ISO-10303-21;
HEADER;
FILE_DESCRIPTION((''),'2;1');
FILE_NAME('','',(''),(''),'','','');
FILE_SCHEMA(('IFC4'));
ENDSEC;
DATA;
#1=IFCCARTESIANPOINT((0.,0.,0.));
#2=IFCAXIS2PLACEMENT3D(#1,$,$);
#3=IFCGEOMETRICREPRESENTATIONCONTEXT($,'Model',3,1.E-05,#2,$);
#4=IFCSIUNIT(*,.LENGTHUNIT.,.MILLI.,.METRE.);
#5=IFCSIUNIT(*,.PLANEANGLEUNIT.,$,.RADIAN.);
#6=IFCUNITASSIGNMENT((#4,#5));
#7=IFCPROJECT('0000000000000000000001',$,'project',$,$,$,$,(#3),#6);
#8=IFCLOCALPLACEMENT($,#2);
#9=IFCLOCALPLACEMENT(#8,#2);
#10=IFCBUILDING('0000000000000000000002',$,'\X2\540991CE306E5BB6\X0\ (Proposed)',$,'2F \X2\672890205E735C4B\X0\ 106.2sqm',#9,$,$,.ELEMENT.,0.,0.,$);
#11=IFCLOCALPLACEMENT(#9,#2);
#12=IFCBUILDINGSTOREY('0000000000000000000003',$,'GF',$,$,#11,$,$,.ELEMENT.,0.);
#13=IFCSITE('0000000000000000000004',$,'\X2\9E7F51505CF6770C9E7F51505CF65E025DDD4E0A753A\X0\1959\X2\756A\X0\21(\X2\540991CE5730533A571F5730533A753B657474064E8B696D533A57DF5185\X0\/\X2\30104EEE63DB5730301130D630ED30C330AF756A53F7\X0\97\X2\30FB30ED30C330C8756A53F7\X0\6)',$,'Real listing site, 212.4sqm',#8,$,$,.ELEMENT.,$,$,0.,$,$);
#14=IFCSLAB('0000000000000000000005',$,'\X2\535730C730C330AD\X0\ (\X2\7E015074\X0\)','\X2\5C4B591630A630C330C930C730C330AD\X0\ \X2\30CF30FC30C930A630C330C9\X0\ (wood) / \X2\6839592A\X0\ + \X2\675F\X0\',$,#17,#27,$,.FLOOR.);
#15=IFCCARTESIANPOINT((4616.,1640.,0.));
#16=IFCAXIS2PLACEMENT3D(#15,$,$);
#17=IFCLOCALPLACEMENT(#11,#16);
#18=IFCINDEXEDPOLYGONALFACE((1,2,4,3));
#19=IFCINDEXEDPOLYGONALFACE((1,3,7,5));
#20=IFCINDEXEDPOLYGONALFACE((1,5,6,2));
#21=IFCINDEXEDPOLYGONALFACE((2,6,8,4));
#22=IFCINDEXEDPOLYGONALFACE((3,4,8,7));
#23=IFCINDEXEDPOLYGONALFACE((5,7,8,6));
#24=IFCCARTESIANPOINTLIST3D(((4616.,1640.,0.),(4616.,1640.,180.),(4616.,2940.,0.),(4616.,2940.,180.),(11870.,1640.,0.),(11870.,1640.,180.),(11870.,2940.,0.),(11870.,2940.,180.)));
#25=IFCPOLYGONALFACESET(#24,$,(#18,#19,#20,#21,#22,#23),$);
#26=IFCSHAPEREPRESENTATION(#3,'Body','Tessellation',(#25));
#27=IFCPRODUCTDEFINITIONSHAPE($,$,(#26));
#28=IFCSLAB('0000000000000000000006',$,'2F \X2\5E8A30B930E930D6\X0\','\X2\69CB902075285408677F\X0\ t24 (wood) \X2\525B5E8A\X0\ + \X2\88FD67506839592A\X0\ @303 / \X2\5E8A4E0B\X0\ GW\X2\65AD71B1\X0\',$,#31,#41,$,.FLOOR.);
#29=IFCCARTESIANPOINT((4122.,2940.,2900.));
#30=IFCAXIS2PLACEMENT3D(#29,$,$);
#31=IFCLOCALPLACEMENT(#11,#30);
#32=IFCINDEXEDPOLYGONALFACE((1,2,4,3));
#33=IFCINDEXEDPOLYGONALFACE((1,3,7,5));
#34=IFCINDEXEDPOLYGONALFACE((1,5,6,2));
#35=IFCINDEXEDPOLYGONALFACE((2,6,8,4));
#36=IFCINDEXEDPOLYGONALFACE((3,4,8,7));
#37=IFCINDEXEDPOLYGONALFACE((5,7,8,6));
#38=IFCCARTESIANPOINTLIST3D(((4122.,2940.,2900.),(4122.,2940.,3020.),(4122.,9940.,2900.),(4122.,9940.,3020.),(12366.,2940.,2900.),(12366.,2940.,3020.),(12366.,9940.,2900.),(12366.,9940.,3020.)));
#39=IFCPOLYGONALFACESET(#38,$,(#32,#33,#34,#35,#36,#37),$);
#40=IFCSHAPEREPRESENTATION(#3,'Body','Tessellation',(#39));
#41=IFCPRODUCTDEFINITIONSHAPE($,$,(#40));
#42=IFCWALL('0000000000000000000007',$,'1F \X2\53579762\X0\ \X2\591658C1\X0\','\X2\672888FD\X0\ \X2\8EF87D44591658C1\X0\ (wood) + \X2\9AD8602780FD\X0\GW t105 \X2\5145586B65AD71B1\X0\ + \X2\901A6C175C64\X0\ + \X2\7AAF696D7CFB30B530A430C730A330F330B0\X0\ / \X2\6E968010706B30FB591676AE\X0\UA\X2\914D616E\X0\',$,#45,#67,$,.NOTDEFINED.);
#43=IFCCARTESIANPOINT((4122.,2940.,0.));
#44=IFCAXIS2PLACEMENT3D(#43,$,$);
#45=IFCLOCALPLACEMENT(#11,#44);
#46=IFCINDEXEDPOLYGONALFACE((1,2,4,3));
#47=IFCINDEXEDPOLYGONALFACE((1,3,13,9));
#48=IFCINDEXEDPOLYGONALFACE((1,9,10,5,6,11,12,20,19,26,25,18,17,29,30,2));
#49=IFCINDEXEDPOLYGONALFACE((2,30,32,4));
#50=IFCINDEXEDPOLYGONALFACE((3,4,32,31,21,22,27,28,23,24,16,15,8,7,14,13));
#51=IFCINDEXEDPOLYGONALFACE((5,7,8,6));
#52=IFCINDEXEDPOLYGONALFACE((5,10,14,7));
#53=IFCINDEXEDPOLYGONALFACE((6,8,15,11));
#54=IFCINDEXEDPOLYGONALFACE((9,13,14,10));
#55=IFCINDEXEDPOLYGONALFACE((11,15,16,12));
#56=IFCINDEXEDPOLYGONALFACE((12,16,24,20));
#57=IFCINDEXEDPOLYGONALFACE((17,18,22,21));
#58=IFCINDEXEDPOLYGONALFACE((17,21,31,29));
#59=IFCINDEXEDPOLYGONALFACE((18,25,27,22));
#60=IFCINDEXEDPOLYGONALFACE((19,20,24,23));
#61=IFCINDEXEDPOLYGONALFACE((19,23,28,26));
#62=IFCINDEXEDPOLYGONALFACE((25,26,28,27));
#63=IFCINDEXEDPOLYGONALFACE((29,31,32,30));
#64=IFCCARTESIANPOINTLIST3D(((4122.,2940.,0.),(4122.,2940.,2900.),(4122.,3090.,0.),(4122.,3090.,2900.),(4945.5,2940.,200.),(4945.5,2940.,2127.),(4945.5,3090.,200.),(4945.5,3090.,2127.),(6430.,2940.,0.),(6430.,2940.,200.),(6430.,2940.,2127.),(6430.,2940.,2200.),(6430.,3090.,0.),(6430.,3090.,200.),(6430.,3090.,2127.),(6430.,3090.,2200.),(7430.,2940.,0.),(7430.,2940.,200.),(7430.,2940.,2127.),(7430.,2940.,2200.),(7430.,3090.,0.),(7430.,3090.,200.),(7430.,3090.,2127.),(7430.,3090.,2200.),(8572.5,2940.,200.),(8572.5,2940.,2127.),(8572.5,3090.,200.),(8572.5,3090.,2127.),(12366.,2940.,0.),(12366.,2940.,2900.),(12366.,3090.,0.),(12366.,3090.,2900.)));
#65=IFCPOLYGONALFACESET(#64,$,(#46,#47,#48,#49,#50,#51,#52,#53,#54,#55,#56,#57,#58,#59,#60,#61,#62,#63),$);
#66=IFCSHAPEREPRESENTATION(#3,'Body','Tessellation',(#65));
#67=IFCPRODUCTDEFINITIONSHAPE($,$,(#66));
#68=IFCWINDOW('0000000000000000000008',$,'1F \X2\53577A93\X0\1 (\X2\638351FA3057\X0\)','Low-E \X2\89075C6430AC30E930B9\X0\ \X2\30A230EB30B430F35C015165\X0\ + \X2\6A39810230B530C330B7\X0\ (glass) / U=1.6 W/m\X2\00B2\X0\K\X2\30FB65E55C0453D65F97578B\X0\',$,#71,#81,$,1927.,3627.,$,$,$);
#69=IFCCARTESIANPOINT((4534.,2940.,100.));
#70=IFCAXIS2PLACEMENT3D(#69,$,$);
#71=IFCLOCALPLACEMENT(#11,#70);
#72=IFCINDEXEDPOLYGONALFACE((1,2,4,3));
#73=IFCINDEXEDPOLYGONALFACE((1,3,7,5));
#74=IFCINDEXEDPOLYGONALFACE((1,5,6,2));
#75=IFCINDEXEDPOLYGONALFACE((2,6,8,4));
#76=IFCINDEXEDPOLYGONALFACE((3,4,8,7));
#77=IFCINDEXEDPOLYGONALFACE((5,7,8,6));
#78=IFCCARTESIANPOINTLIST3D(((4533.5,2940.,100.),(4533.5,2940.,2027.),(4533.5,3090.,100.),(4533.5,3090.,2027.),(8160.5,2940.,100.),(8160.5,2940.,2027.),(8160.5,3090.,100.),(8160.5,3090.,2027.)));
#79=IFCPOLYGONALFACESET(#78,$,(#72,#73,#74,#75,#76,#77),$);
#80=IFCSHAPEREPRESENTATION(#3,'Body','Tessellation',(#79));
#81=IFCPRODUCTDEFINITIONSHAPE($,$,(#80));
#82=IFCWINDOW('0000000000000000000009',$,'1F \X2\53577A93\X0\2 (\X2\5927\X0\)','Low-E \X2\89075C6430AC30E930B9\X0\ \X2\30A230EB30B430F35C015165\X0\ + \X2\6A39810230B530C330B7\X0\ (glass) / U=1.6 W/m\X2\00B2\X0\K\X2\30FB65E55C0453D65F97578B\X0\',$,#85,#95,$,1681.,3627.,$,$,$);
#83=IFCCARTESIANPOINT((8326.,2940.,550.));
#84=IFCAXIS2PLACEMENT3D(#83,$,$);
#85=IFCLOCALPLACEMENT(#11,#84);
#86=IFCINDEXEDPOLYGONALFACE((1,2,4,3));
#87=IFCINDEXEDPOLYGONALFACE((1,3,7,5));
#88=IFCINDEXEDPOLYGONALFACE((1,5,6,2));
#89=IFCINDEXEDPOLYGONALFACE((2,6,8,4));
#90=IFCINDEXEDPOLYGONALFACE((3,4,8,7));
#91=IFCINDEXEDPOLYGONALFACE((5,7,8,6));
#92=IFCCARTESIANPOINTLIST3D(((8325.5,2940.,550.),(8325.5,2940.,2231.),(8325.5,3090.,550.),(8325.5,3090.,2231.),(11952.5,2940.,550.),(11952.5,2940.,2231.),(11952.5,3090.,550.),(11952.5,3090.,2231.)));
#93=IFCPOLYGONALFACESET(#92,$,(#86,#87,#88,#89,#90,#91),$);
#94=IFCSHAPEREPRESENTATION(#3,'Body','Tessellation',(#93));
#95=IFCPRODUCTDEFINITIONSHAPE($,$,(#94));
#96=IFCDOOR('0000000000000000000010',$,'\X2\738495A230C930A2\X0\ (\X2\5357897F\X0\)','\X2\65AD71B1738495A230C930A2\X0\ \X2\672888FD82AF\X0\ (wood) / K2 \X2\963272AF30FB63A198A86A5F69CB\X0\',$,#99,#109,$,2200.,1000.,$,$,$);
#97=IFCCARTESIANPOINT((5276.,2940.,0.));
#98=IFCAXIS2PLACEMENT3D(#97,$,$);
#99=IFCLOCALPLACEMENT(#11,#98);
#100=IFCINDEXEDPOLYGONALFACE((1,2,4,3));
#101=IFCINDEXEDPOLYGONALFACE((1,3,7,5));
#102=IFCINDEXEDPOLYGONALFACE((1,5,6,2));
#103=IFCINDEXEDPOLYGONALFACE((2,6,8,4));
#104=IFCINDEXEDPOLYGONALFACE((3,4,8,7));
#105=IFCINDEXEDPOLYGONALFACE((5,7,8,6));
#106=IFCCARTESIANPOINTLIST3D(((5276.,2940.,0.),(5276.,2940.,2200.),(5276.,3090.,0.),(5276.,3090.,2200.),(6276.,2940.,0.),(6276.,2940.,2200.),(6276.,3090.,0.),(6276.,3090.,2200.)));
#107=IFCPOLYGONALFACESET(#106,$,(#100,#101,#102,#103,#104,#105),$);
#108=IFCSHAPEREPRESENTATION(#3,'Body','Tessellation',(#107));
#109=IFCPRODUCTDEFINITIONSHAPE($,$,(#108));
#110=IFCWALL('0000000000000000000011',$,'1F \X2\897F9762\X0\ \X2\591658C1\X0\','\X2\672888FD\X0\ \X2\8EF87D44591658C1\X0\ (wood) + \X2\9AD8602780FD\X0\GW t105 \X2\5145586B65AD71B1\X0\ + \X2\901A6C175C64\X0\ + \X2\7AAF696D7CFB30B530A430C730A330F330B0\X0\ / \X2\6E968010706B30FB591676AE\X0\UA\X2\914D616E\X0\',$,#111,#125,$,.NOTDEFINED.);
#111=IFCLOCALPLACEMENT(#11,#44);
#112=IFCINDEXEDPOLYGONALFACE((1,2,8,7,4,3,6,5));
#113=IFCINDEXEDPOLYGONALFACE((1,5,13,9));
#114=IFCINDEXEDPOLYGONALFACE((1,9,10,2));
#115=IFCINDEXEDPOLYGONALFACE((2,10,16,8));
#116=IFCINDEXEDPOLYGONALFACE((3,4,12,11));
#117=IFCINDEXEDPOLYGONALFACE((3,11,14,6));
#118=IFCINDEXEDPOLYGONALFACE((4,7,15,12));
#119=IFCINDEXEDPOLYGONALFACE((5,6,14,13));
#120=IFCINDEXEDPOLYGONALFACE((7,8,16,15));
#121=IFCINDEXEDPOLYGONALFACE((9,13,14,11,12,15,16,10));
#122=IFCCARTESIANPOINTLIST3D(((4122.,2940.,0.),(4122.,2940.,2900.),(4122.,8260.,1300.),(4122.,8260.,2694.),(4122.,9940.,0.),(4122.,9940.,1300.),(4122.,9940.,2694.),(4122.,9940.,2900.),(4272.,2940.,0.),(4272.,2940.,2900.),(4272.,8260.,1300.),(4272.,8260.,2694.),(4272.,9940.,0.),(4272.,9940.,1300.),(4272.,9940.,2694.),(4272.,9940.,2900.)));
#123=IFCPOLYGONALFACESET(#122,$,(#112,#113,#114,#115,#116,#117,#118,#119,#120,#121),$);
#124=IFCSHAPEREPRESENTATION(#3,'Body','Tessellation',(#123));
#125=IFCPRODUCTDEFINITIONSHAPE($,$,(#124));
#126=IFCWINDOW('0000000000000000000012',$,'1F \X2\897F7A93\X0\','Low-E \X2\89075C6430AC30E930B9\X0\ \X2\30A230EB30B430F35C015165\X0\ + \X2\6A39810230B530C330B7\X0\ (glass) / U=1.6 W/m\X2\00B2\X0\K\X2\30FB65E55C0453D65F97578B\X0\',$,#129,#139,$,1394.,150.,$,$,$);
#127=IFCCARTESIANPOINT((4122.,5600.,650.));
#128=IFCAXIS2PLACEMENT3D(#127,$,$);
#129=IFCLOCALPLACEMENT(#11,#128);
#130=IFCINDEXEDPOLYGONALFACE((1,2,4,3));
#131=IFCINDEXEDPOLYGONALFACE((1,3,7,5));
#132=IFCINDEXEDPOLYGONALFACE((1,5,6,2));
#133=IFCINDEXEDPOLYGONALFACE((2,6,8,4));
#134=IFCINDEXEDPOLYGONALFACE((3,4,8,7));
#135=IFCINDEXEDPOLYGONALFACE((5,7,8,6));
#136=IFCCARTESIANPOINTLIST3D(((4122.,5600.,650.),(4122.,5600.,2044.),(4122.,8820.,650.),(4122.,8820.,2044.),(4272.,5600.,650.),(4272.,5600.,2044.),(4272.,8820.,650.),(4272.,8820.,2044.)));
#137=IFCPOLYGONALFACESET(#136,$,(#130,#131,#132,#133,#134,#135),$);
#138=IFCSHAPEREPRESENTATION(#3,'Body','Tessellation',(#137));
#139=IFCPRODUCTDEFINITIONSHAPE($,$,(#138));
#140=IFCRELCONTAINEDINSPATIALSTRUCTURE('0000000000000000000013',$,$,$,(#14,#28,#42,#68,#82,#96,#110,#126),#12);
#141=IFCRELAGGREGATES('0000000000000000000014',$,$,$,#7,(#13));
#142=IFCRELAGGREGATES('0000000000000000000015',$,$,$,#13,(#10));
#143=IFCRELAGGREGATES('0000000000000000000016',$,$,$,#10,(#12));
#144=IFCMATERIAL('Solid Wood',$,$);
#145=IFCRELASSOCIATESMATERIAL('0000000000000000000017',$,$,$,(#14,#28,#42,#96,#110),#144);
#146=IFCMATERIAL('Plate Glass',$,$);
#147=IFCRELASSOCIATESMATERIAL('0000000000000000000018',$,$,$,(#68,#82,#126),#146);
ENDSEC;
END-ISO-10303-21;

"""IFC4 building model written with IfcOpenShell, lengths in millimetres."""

from ifc_helpers import new_model, si_unit, frame, frame_2d, origin, place, context, project, spatial, rectangle, extrude, material, element, fill, save


model = new_model("IFC4")

# Units and contexts
model_context = context("Model", 3, precision=1e-05, world=origin())
ifc_project = project(units=[si_unit("LENGTHUNIT", "METRE", prefix="MILLI"), si_unit("PLANEANGLEUNIT", "RADIAN")], contexts=[model_context])

# Site, building, storey
site_placement = place(None, origin())
site = spatial("IfcSite", under=ifc_project, at=site_placement, Name="鹿児島県鹿児島市川上町1959番21(吉野地区土地区画整理事業区域内/【仮換地】ブロック番号97・ロット番号6)", ObjectType="Real listing site, 212.4sqm", CompositionType="ELEMENT", RefElevation=0.0)
building_placement = place(site_placement, origin())
building = spatial("IfcBuilding", under=site, at=building_placement, Name="吉野の家 (Proposed)", ObjectType="2F 木造平屋 106.2sqm", CompositionType="ELEMENT", ElevationOfRefHeight=0.0, ElevationOfTerrain=0.0)
storey_placement = place(building_placement, origin())
storey = spatial("IfcBuildingStorey", under=building, at=storey_placement, Name="GF", CompositionType="ELEMENT", Elevation=0.0)

# Slabs
ifc_material_1 = material(Name="Solid Wood")
slab_1_placement = place(storey_placement, frame((4616.0, 1640.0, 0.0)))
element("IfcSlab", 1, at=slab_1_placement, inside=storey, material=ifc_material_1, Name="南デッキ (縁側)", Description="屋外ウッドデッキ ハードウッド (wood) / 根太 + 束", PredefinedType="FLOOR", context=model_context, shape_type="SweptSolid", body=[
    extrude(rectangle(XDim=7254.0, YDim=1300.0, at=frame_2d((3627.0, 650.0))), frame((4616.0, 1640.0, 0.0)), (0.0, 0.0, 1.0), 180.0),
])
slab_2_placement = place(storey_placement, frame((4122.0, 2940.0, 2900.0)))
element("IfcSlab", 2, at=slab_2_placement, inside=storey, material=ifc_material_1, Name="2F 床スラブ", Description="構造用合板 t24 (wood) 剛床 + 製材根太 @303 / 床下 GW断熱", PredefinedType="FLOOR", context=model_context, shape_type="SweptSolid", body=[
    extrude(rectangle(XDim=8244.0, YDim=7000.0, at=frame_2d((4122.0, 3500.0))), frame((4122.0, 2940.0, 2900.0)), (0.0, 0.0, 1.0), 120.0),
])

# Wall, openings, windows, door
wall_1_placement = place(storey_placement, frame((4122.0, 2940.0, 0.0)))
wall_1 = element("IfcWall", 3, at=wall_1_placement, inside=storey, material=ifc_material_1, Name="1F 南面 外壁", Description="木製 軸組外壁 (wood) + 高性能GW t105 充填断熱 + 通気層 + 窯業系サイディング / 準耐火・外皮UA配慮", PredefinedType="NOTDEFINED", context=model_context, shape_type="SweptSolid", body=[
    extrude(rectangle(XDim=8244.0, YDim=150.0, at=frame_2d((4122.0, 75.0))), frame((4122.0, 2940.0, 0.0)), (0.0, 0.0, 1.0), 2900.0),
])
opening_1_placement = place(storey_placement, frame((4534.0, 2940.0, 100.0)))
opening_1 = element("IfcOpeningElement", 4, at=opening_1_placement, cuts=wall_1, PredefinedType="NOTDEFINED", context=model_context, shape_type="SweptSolid", body=[
    extrude(rectangle(XDim=3627.0, YDim=150.0, at=frame_2d((1813.0, 75.0))), frame((4534.0, 2940.0, 100.0)), (0.0, 0.0, 1.0), 1927.0),
])
opening_2_placement = place(storey_placement, frame((8326.0, 2940.0, 550.0)))
opening_2 = element("IfcOpeningElement", 5, at=opening_2_placement, cuts=wall_1, PredefinedType="NOTDEFINED", context=model_context, shape_type="SweptSolid", body=[
    extrude(rectangle(XDim=3627.0, YDim=150.0, at=frame_2d((1813.0, 75.0))), frame((8326.0, 2940.0, 550.0)), (0.0, 0.0, 1.0), 1681.0),
])
opening_3_placement = place(storey_placement, frame((5276.0, 2940.0, 0.0)))
opening_3 = element("IfcOpeningElement", 6, at=opening_3_placement, cuts=wall_1, PredefinedType="NOTDEFINED", context=model_context, shape_type="SweptSolid", body=[
    extrude(rectangle(XDim=1000.0, YDim=150.0, at=frame_2d((500.0, 75.0))), frame((5276.0, 2940.0, 0.0)), (0.0, 0.0, 1.0), 2200.0),
])
ifc_material_2 = material(Name="Plate Glass")
window_1_placement = place(storey_placement, frame((4534.0, 2940.0, 100.0)))
window_1 = element("IfcWindow", 7, at=window_1_placement, inside=storey, material=ifc_material_2, Name="1F 南窓1 (掃出し)", Description="Low-E 複層ガラス アルゴン封入 + 樹脂サッシ (glass) / U=1.6 W/m²K・日射取得型", OverallHeight=1927.0, OverallWidth=3627.0, context=model_context, shape_type="SweptSolid", body=[
    extrude(rectangle(XDim=3627.0, YDim=150.0, at=frame_2d((1813.0, 75.0))), frame((4534.0, 2940.0, 100.0)), (0.0, 0.0, 1.0), 1927.0),
])
fill(opening_1, window_1)
window_2_placement = place(storey_placement, frame((8326.0, 2940.0, 550.0)))
window_2 = element("IfcWindow", 8, at=window_2_placement, inside=storey, material=ifc_material_2, Name="1F 南窓2 (大)", Description="Low-E 複層ガラス アルゴン封入 + 樹脂サッシ (glass) / U=1.6 W/m²K・日射取得型", OverallHeight=1681.0, OverallWidth=3627.0, context=model_context, shape_type="SweptSolid", body=[
    extrude(rectangle(XDim=3627.0, YDim=150.0, at=frame_2d((1813.0, 75.0))), frame((8326.0, 2940.0, 550.0)), (0.0, 0.0, 1.0), 1681.0),
])
fill(opening_2, window_2)
door_placement = place(storey_placement, frame((5276.0, 2940.0, 0.0)))
door = element("IfcDoor", 9, at=door_placement, inside=storey, material=ifc_material_1, Name="玄関ドア (南西)", Description="断熱玄関ドア 木製芯 (wood) / K2 防犯・採風機構", OverallHeight=2200.0, OverallWidth=1000.0, context=model_context, shape_type="SweptSolid", body=[
    extrude(rectangle(XDim=1000.0, YDim=150.0, at=frame_2d((500.0, 75.0))), frame((5276.0, 2940.0, 0.0)), (0.0, 0.0, 1.0), 2200.0),
])
fill(opening_3, door)

# Wall, opening, window
wall_2_placement = place(storey_placement, frame((4122.0, 2940.0, 0.0)))
wall_2 = element("IfcWall", 10, at=wall_2_placement, inside=storey, material=ifc_material_1, Name="1F 西面 外壁", Description="木製 軸組外壁 (wood) + 高性能GW t105 充填断熱 + 通気層 + 窯業系サイディング / 準耐火・外皮UA配慮", PredefinedType="NOTDEFINED", context=model_context, shape_type="SweptSolid", body=[
    extrude(rectangle(XDim=150.0, YDim=7000.0, at=frame_2d((75.0, 3500.0))), frame((4122.0, 2940.0, 0.0)), (0.0, 0.0, 1.0), 2900.0),
])
opening_4_placement = place(storey_placement, frame((4122.0, 5600.0, 650.0)))
opening_4 = element("IfcOpeningElement", 11, at=opening_4_placement, cuts=wall_2, PredefinedType="NOTDEFINED", context=model_context, shape_type="SweptSolid", body=[
    extrude(rectangle(XDim=150.0, YDim=3220.0, at=frame_2d((75.0, 1610.0))), frame((4122.0, 5600.0, 650.0)), (0.0, 0.0, 1.0), 1394.0),
])
window_3_placement = place(storey_placement, frame((4122.0, 5600.0, 650.0)))
window_3 = element("IfcWindow", 12, at=window_3_placement, inside=storey, material=ifc_material_2, Name="1F 西窓", Description="Low-E 複層ガラス アルゴン封入 + 樹脂サッシ (glass) / U=1.6 W/m²K・日射取得型", OverallHeight=1394.0, OverallWidth=150.0, context=model_context, shape_type="SweptSolid", body=[
    extrude(rectangle(XDim=150.0, YDim=3220.0, at=frame_2d((75.0, 1610.0))), frame((4122.0, 5600.0, 650.0)), (0.0, 0.0, 1.0), 1394.0),
])
fill(opening_4, window_3)

save(model, "model.ifc")
